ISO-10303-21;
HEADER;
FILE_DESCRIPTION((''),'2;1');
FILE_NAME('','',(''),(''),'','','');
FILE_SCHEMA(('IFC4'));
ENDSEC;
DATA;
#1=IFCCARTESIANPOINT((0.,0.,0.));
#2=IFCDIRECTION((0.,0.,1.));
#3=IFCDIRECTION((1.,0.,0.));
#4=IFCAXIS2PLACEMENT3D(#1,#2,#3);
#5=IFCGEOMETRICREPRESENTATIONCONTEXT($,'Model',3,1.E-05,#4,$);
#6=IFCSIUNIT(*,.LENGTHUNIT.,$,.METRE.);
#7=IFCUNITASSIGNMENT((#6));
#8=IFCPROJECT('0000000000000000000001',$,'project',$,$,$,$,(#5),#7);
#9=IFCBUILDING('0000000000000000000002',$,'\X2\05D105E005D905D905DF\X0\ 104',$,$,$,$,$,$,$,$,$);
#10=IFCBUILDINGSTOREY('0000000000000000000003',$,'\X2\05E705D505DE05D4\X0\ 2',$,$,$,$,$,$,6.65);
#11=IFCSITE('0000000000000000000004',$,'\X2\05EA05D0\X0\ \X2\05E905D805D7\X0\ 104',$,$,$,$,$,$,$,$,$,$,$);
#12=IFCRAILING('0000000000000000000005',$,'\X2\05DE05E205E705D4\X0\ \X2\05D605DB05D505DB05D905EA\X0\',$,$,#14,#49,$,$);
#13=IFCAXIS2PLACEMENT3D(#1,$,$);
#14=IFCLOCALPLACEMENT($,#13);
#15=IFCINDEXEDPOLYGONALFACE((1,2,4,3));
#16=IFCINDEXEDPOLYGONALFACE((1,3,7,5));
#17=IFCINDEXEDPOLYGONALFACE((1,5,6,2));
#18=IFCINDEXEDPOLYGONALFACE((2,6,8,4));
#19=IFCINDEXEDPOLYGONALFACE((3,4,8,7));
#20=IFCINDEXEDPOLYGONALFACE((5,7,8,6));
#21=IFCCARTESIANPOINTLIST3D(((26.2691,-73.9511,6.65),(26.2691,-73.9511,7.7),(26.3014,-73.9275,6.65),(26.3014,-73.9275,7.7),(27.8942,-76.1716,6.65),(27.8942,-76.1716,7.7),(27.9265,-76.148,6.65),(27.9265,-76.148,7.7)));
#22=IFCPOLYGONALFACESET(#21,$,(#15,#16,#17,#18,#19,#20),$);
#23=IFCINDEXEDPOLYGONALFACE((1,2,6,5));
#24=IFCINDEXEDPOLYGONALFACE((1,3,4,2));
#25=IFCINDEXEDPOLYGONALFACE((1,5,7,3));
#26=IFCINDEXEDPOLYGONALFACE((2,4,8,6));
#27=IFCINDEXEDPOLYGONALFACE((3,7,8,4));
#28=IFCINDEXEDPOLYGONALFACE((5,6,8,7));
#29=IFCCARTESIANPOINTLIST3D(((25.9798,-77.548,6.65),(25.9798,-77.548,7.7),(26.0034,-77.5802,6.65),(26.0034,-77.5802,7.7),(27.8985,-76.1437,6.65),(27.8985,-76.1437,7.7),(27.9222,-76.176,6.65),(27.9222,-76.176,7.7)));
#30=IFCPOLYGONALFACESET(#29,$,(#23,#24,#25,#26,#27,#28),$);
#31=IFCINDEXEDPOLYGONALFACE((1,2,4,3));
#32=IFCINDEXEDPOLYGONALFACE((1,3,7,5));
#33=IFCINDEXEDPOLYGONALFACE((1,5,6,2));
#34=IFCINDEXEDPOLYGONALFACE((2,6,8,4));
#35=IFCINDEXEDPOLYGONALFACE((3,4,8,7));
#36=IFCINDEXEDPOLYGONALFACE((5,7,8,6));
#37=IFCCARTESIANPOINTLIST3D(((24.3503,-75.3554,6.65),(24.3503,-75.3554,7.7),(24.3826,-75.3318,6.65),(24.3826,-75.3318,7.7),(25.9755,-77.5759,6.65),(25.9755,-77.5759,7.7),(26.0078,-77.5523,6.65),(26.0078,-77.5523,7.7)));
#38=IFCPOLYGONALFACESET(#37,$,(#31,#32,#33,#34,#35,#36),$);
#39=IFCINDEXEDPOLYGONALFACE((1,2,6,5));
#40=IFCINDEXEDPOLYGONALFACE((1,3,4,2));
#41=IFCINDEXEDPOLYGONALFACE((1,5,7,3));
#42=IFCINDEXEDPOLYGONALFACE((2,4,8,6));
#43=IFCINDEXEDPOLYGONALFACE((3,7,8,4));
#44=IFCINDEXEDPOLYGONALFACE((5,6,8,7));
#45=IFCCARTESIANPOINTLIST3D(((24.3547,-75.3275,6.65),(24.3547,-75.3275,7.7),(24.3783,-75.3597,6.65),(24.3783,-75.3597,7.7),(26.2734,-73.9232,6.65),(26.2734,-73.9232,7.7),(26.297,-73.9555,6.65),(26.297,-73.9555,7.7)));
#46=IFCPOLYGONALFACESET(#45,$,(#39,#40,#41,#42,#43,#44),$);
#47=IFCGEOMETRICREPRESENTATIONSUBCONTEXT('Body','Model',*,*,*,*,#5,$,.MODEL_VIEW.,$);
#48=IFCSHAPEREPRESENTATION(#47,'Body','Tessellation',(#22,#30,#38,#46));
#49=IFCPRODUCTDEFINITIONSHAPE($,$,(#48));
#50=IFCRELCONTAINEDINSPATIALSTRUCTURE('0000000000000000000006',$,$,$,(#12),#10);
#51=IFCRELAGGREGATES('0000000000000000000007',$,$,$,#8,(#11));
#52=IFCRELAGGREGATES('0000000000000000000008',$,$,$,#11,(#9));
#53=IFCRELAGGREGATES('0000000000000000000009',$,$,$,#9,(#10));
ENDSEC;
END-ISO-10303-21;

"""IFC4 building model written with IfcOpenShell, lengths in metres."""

from ifc_helpers import new_model, si_unit, frame, origin_with_axes, context, subcontext, project, spatial, polyline, outline, extrude, element, save


model = new_model("IFC4")

# Units and contexts
model_context = context("Model", 3, precision=1e-05, world=origin_with_axes())
body_context = subcontext(model_context, "Body", "Model", "MODEL_VIEW")
ifc_project = project(units=[si_unit("LENGTHUNIT", "METRE")], contexts=[model_context])

# Site, building, storey
site = spatial("IfcSite", under=ifc_project, Name="תא שטח 104")
building = spatial("IfcBuilding", under=site, Name="בניין 104")
storey = spatial("IfcBuildingStorey", under=building, Name="קומה 2", Elevation=6.65)

# Railing
element("IfcRailing", 1, inside=storey, Name="מעקה זכוכית", context=body_context, shape_type="SweptSolid", body=[
    extrude(outline(polyline([(26.2691, -73.9511), (27.8942, -76.1716), (27.9265, -76.148), (26.3014, -73.9275), (26.2691, -73.9511)])), frame((0.0, 0.0, 6.65)), (0.0, 0.0, 1.0), 1.05),
    extrude(outline(polyline([(27.8985, -76.1437), (25.9798, -77.548), (26.0034, -77.5802), (27.9222, -76.176), (27.8985, -76.1437)])), frame((0.0, 0.0, 6.65)), (0.0, 0.0, 1.0), 1.05),
    extrude(outline(polyline([(26.0078, -77.5523), (24.3826, -75.3318), (24.3503, -75.3554), (25.9755, -77.5759), (26.0078, -77.5523)])), frame((0.0, 0.0, 6.65)), (0.0, 0.0, 1.0), 1.05),
    extrude(outline(polyline([(24.3783, -75.3597), (26.297, -73.9555), (26.2734, -73.9232), (24.3547, -75.3275), (24.3783, -75.3597)])), frame((0.0, 0.0, 6.65)), (0.0, 0.0, 1.0), 1.05),
])

save(model, "model.ifc")
